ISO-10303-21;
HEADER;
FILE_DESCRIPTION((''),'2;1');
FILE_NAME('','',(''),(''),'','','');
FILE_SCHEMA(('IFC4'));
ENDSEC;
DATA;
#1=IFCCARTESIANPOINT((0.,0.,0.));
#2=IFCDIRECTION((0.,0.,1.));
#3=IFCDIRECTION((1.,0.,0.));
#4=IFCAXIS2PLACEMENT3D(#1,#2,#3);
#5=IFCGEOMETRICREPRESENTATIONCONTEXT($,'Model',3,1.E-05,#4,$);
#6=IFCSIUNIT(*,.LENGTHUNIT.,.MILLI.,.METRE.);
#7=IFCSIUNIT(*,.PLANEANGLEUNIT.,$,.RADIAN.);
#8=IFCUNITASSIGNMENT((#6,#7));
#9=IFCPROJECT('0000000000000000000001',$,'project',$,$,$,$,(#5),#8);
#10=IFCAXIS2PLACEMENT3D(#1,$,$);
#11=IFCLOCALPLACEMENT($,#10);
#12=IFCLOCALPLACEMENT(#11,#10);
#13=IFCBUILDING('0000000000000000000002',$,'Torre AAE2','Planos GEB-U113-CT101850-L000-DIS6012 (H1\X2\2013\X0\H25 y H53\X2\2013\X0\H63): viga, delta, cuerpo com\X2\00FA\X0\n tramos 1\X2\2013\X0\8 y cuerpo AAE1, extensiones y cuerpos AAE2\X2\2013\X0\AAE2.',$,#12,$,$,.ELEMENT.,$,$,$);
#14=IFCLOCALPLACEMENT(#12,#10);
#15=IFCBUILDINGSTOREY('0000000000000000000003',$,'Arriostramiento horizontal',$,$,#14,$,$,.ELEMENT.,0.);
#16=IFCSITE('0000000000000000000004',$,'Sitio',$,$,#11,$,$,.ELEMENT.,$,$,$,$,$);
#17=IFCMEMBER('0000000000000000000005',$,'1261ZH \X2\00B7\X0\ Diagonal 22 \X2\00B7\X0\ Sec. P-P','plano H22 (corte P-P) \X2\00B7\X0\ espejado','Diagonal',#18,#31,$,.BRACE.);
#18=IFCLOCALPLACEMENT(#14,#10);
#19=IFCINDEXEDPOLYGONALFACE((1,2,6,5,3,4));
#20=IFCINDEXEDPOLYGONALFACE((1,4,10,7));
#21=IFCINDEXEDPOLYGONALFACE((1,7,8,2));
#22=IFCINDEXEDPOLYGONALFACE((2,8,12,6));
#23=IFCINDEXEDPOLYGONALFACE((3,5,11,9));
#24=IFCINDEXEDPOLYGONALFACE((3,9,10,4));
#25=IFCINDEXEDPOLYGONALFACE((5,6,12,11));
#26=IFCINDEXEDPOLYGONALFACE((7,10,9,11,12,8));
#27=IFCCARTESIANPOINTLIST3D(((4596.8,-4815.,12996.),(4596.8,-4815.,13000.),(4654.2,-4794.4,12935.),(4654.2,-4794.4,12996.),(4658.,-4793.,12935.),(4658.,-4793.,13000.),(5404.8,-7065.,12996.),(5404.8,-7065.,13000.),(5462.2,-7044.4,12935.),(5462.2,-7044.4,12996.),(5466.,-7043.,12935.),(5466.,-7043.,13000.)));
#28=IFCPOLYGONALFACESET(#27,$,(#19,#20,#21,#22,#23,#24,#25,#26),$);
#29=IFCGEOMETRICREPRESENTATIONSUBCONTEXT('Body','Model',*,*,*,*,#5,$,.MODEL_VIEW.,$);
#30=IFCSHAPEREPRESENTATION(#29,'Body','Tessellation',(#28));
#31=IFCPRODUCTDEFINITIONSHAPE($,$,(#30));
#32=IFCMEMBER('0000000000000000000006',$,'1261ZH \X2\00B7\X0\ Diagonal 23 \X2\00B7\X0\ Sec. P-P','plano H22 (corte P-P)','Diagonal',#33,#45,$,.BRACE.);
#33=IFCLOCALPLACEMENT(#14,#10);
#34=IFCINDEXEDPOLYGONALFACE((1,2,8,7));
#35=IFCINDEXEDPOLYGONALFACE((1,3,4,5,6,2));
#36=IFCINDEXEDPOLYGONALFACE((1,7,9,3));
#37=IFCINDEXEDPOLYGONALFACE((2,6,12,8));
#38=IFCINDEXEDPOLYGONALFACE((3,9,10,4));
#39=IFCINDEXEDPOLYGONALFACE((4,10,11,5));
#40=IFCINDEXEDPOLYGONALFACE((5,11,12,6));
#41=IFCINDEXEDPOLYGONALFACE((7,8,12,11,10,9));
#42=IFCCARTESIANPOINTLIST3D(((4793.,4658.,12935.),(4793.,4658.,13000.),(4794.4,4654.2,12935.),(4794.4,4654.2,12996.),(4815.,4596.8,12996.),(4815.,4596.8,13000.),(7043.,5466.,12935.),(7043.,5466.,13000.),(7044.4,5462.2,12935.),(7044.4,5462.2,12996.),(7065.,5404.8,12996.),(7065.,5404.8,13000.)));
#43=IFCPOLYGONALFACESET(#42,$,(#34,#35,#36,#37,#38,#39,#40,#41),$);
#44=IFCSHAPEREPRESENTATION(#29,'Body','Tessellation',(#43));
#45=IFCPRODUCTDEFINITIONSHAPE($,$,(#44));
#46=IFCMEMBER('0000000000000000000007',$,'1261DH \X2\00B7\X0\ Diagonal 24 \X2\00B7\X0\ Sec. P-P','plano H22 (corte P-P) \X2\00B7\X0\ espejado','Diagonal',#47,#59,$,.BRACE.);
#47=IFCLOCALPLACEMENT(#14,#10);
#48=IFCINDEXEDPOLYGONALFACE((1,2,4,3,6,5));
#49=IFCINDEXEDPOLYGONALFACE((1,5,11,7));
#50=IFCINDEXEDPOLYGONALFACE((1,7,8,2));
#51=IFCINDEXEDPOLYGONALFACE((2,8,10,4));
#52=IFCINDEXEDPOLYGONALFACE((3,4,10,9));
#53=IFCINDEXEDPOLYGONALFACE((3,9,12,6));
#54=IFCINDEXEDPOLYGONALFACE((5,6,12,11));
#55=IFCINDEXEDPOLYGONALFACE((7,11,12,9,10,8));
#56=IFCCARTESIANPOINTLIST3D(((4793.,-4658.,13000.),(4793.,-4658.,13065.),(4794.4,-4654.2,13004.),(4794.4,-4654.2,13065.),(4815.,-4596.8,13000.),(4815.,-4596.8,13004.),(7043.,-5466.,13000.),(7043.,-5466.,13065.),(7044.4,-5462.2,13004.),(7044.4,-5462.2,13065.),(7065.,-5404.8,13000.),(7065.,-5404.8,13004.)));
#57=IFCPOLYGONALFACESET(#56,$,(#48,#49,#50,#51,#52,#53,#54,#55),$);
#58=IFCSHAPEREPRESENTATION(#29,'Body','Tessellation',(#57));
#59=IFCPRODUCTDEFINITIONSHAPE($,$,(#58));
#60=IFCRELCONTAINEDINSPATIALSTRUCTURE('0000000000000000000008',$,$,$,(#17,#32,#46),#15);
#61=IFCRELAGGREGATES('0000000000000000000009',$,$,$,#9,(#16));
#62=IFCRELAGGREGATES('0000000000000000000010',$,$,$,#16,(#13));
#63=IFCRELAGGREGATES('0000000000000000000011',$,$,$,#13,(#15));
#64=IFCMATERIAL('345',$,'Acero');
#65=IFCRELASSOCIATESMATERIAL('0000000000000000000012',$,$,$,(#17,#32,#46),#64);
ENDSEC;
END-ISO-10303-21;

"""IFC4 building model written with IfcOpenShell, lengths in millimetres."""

from ifc_helpers import new_model, si_unit, frame, frame_2d, origin, origin_with_axes, place, context, subcontext, project, spatial, l_section, extrude, material, element, save


model = new_model("IFC4")

# Units and contexts
model_context = context("Model", 3, precision=1e-05, world=origin_with_axes())
body_context = subcontext(model_context, "Body", "Model", "MODEL_VIEW")
ifc_project = project(units=[si_unit("LENGTHUNIT", "METRE", prefix="MILLI"), si_unit("PLANEANGLEUNIT", "RADIAN")], contexts=[model_context])

# Site, building, storey
site_placement = place(None, origin())
site = spatial("IfcSite", under=ifc_project, at=site_placement, Name="Sitio", CompositionType="ELEMENT")
building_placement = place(site_placement, origin())
building = spatial("IfcBuilding", under=site, at=building_placement, Name="Torre AAE2", Description="Planos GEB-U113-CT101850-L000-DIS6012 (H1–H25 y H53–H63): viga, delta, cuerpo común tramos 1–8 y cuerpo AAE1, extensiones y cuerpos AAE2–AAE2.", CompositionType="ELEMENT")
storey_placement = place(building_placement, origin())
storey = spatial("IfcBuildingStorey", under=building, at=storey_placement, Name="Arriostramiento horizontal", CompositionType="ELEMENT", Elevation=0.0)

# Members
ifc_material_1 = material(Name="345", Category="Acero")
for number, where, z_axis, x_axis, name, description in (
    (1, (4658.0, -4793.0, 13000.0), (0.337979, -0.941154, 0.0), (-0.941154, -0.337979, 0.0), "1261ZH · Diagonal 22 · Sec. P-P", "plano H22 (corte P-P) · espejado"),
    (2, (4793.0, 4658.0, 13000.0), (0.941154, 0.337979, 0.0), (0.337979, -0.941154, 0.0), "1261ZH · Diagonal 23 · Sec. P-P", "plano H22 (corte P-P)"),
    (3, (4793.0, -4658.0, 13000.0), (0.941154, -0.337979, 0.0), (0.337979, 0.941154, 0.0), "1261DH · Diagonal 24 · Sec. P-P", "plano H22 (corte P-P) · espejado"),
):
    element("IfcMember", number, at=place(storey_placement, frame(where, z_axis=z_axis, x_axis=x_axis)), inside=storey, material=ifc_material_1, Name=name, Description=description, ObjectType="Diagonal", PredefinedType="BRACE", context=body_context, shape_type="SweptSolid", body=[
        extrude(l_section(Depth=65.0, Width=65.0, Thickness=4.0, at=frame_2d((32.5, 32.5))), None, (0.0, 0.0, 1.0), 2390.7),
    ])

save(model, "model.ifc")
